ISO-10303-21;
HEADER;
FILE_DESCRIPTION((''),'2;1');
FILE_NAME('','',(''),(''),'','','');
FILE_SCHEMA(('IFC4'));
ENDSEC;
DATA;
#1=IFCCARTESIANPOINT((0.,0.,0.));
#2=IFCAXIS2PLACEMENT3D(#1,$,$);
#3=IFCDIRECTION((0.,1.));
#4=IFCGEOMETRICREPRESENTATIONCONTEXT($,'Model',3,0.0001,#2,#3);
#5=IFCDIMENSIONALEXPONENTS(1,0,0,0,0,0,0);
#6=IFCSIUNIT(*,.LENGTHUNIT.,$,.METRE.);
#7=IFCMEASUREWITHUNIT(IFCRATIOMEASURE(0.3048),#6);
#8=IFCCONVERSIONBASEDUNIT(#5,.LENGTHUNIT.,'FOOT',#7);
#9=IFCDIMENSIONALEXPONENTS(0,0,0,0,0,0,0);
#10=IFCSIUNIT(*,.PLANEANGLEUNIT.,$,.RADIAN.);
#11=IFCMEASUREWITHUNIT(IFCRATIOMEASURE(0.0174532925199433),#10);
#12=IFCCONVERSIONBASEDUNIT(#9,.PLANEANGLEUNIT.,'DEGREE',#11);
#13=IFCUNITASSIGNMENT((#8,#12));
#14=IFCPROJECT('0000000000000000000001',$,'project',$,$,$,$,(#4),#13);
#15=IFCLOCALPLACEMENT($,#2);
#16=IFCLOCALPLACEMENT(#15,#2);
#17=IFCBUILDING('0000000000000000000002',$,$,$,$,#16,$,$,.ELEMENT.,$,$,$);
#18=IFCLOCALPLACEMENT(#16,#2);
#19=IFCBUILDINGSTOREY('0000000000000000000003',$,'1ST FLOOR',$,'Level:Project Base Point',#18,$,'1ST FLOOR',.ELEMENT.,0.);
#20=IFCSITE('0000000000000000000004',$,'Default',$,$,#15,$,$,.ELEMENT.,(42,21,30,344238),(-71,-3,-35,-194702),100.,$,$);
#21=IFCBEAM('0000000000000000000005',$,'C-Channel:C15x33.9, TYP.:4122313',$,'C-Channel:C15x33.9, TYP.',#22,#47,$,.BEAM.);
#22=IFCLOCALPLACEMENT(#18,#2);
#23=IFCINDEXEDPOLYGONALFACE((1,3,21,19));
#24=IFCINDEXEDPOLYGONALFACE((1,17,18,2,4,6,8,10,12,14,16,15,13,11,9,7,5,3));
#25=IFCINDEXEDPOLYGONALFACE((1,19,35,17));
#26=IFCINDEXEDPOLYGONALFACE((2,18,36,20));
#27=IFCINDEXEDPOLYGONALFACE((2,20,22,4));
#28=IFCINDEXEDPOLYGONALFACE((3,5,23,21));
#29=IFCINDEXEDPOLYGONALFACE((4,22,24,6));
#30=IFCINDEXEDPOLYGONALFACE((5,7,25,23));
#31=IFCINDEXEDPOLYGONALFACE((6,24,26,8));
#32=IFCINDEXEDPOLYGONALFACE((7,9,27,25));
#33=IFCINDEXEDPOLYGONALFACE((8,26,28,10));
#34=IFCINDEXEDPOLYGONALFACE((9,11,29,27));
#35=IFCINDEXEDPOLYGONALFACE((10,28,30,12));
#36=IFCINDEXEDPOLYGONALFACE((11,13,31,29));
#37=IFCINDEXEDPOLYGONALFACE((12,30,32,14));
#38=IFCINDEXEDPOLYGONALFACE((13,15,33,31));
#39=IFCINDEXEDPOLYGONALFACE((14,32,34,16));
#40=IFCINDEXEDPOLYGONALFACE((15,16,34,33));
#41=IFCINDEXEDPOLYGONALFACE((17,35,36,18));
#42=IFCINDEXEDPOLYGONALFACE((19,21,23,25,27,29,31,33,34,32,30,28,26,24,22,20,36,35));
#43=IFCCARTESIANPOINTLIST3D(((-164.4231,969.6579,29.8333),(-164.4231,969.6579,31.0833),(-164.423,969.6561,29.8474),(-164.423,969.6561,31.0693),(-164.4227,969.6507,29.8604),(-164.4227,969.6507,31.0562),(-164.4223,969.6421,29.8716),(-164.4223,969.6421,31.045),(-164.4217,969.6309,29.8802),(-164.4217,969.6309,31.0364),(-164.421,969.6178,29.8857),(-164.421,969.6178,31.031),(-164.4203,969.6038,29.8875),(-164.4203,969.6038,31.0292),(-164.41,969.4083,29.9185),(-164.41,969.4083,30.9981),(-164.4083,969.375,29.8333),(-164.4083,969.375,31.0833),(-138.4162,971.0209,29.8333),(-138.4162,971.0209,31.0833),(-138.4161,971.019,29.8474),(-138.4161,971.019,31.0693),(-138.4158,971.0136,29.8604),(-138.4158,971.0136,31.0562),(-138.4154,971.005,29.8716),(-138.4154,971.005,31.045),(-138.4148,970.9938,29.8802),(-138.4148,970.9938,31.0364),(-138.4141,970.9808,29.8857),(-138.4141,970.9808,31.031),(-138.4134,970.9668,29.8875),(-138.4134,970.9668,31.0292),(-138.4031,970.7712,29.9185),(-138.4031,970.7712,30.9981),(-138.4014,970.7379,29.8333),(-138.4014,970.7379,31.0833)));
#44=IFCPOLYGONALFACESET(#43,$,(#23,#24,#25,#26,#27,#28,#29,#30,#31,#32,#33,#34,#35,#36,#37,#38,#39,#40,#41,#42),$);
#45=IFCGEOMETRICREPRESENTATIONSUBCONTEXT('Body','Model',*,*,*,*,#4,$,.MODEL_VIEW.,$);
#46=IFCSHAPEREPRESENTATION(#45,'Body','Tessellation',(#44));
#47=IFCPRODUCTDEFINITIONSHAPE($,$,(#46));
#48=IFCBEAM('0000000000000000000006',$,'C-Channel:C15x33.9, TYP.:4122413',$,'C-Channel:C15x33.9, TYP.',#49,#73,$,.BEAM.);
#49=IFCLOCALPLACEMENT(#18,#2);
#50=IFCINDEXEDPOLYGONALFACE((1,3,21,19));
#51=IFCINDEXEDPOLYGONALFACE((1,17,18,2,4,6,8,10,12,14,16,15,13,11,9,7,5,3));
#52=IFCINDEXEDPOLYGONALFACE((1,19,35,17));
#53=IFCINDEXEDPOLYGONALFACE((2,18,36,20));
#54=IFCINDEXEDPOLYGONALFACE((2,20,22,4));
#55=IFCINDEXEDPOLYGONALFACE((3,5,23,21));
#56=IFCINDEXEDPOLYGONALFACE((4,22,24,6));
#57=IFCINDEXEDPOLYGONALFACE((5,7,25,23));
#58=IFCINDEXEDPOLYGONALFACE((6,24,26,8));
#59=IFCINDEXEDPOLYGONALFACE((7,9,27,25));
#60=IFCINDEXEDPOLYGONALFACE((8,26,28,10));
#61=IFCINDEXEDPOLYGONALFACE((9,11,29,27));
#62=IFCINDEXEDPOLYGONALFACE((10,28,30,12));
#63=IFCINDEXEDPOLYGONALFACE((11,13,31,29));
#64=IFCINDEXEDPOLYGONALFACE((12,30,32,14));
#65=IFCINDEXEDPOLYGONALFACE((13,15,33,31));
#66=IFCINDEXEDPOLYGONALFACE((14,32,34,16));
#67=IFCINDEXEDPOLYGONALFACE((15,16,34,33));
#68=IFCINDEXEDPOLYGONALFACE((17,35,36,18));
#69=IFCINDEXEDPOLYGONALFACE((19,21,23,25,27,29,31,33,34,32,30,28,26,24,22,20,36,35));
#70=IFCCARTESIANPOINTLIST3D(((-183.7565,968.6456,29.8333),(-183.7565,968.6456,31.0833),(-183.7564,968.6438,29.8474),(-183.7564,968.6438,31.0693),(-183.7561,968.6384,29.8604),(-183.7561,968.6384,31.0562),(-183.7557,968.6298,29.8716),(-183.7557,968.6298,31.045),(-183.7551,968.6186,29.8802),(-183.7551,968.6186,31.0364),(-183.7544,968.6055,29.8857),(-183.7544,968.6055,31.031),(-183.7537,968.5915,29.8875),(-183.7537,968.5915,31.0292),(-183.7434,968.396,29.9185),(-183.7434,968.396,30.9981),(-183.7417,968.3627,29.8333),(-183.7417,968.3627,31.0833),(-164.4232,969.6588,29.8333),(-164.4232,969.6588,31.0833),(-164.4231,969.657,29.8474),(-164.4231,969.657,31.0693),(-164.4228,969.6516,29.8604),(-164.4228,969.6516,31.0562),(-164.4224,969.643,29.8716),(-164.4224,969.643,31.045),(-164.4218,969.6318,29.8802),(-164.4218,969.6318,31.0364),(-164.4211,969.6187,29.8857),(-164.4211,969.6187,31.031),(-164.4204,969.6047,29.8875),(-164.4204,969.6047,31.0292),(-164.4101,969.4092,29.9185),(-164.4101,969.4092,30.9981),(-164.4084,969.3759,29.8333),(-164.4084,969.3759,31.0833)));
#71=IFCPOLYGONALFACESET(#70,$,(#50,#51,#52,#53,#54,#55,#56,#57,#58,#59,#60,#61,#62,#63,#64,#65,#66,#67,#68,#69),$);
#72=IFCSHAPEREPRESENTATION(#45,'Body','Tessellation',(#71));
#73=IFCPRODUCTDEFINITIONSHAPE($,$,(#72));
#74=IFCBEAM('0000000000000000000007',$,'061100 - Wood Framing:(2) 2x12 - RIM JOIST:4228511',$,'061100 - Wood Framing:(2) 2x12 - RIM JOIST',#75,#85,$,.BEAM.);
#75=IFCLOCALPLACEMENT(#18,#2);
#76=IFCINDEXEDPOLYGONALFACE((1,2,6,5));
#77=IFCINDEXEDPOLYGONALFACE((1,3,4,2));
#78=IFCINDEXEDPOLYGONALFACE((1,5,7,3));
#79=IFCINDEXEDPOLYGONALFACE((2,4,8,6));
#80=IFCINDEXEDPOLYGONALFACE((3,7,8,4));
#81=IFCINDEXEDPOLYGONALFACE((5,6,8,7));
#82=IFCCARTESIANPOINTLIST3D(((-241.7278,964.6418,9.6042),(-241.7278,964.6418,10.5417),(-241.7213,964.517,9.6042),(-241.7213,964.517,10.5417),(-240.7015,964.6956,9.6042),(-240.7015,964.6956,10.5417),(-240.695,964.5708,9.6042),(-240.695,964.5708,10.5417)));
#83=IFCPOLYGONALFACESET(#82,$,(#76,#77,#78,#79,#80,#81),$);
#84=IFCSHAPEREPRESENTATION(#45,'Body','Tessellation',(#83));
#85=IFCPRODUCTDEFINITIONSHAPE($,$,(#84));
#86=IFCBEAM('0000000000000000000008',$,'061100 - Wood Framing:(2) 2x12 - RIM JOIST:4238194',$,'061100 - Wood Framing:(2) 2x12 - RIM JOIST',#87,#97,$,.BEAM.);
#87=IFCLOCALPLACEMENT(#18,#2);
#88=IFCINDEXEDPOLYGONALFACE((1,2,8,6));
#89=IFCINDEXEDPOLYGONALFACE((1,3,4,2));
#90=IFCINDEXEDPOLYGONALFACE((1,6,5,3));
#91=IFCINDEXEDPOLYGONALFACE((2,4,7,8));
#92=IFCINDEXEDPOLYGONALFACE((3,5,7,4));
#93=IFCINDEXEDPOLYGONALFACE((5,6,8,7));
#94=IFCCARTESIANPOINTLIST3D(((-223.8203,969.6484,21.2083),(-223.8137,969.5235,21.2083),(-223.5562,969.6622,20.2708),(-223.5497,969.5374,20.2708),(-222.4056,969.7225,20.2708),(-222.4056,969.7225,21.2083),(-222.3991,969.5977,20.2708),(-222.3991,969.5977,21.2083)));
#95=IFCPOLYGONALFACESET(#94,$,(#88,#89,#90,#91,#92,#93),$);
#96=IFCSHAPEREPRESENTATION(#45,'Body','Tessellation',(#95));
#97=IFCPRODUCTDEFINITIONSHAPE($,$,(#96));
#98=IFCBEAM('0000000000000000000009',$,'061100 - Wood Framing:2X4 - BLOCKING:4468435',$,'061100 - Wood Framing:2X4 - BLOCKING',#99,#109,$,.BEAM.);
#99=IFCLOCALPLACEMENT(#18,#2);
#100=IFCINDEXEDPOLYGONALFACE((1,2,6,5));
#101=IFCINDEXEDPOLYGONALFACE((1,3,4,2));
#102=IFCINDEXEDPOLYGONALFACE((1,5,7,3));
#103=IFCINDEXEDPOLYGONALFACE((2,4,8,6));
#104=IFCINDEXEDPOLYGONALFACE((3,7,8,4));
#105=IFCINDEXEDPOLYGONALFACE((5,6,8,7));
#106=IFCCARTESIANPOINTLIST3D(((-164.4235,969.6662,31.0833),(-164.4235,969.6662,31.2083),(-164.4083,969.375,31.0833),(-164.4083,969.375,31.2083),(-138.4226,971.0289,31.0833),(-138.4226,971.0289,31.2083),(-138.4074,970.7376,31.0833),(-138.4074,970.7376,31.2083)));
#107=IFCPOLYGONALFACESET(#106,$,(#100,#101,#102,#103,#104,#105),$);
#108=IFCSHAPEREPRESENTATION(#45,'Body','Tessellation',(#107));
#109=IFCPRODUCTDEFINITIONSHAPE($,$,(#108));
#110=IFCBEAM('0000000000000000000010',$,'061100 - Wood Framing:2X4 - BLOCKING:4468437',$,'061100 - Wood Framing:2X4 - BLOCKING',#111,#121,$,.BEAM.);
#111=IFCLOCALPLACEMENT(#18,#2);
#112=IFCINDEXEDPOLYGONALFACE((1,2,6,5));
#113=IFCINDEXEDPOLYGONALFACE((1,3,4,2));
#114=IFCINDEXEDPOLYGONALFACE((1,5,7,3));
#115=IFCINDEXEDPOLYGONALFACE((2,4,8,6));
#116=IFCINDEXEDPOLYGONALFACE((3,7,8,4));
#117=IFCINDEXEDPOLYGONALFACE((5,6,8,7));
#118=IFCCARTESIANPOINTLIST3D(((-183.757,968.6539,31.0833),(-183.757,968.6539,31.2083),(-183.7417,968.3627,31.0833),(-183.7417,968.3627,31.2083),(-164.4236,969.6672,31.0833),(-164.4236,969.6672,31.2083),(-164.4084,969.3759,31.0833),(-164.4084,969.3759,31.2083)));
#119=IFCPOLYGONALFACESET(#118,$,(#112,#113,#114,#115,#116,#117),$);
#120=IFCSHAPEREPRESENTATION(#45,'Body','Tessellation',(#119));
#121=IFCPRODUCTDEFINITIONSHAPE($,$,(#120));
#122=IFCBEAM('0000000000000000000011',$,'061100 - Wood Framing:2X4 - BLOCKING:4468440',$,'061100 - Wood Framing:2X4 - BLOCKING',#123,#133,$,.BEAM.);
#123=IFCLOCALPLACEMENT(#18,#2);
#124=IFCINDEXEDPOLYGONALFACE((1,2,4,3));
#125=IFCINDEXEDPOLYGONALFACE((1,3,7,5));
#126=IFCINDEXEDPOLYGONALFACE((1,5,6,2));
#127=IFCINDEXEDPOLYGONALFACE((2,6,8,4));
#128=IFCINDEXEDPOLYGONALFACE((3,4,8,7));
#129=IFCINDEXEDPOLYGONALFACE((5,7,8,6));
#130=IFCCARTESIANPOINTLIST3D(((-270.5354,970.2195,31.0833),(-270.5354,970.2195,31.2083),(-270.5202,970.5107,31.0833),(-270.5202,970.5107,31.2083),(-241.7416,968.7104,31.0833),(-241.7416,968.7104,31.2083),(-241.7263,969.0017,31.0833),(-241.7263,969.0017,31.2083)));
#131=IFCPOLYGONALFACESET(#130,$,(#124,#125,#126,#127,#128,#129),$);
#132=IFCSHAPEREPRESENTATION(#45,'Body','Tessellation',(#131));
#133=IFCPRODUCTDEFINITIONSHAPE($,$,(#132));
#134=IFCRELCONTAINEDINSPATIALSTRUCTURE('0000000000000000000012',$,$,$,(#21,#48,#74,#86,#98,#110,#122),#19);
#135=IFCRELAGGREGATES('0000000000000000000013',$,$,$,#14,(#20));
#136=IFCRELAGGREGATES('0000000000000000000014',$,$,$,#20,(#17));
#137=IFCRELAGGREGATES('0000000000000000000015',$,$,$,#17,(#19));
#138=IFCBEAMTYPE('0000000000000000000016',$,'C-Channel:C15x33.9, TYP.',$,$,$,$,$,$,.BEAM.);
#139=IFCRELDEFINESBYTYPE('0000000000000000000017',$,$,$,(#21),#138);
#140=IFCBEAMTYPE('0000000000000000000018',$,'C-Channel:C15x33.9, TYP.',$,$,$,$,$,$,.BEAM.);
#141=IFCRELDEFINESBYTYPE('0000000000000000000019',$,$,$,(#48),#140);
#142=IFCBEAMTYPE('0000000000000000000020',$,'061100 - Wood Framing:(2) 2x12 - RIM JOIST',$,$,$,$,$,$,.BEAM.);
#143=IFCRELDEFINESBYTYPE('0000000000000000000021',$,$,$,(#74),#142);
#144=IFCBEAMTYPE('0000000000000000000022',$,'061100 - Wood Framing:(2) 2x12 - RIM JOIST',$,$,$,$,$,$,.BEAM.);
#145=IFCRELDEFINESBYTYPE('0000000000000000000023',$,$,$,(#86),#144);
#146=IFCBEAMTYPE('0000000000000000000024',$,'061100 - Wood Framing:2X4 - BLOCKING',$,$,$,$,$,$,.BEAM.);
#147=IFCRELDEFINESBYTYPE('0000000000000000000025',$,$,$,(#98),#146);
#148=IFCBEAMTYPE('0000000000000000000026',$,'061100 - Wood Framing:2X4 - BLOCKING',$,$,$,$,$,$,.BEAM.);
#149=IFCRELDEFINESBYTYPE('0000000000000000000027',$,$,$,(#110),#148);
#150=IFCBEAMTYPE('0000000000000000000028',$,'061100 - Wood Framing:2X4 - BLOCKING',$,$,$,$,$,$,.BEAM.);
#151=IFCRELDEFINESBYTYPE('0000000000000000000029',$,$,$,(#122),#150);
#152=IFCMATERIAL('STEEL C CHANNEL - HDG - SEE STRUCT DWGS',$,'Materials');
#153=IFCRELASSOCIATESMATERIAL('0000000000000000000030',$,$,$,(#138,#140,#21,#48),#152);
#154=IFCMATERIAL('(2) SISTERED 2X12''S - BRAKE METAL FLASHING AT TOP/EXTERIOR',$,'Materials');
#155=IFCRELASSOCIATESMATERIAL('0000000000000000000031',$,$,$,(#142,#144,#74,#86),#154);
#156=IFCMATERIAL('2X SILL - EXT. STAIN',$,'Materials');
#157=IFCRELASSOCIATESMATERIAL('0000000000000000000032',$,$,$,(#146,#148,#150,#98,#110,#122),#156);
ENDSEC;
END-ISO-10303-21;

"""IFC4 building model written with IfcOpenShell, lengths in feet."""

from ifc_helpers import new_model, entity, si_unit, converted_unit, direction, frame, frame_2d, origin, origin_2d_with_axis, place, context, subcontext, project, spatial, polyline, circle_curve, parameter, trimmed, segment, composite_curve, rectangle, outline, extrude, clip, halfspace, source, transform, mapped, material, material_profile, profile_set, profile_usage, type_object, type_shapes, element, save


model = new_model("IFC4")

# Units and contexts
model_context = context("Model", 3, precision=0.0001, world=origin(), true_north=direction((0.0, 1.0)))
body_context = subcontext(model_context, "Body", "Model", "MODEL_VIEW")
ifc_project = project(units=[converted_unit("LENGTHUNIT", "FOOT", entity("IfcRatioMeasure", 0.3048), si_unit("LENGTHUNIT", "METRE"), dimensions=[1, 0, 0, 0, 0, 0, 0]), converted_unit("PLANEANGLEUNIT", "DEGREE", entity("IfcRatioMeasure", 0.0174532925199433), si_unit("PLANEANGLEUNIT", "RADIAN"), dimensions=[0, 0, 0, 0, 0, 0, 0])], contexts=[model_context])

# Site, building, storey
site_placement = place(None, origin())
site = spatial("IfcSite", under=ifc_project, at=site_placement, Name="Default", CompositionType="ELEMENT", RefLatitude=(42, 21, 30, 344238), RefLongitude=(-71, -3, -35, -194702), RefElevation=100.0)
building_placement = place(site_placement, origin())
building = spatial("IfcBuilding", under=site, at=building_placement, CompositionType="ELEMENT")
storey_placement = place(building_placement, origin())
storey = spatial("IfcBuildingStorey", under=building, at=storey_placement, Name="1ST FLOOR", ObjectType="Level:Project Base Point", LongName="1ST FLOOR", CompositionType="ELEMENT", Elevation=0.0)

# Beams
ifc_material_1 = material(Name="STEEL C CHANNEL - HDG - SEE STRUCT DWGS", Category="Materials")
ifc_material_profile_1 = material_profile(ifc_material_1, outline(composite_curve([segment(polyline([(0.0323, -0.5398, 0.0), (0.0323, 0.5398, 0.0)]), True, "CONTINUOUS"), segment(polyline([(0.0323, 0.5398, 0.0), (-0.1635, 0.5708, 0.0)]), True, "CONTINUOUS"), segment(trimmed(circle_curve(frame((-0.1635, 0.625, 0.0), z_axis=(0.0, 0.0, -1.0), x_axis=(-1.0, 0.0, 0.0)), 0.0542), [parameter(270.0)], [parameter(360.0)], True, "PARAMETER"), True, "CONTINUOUS"), segment(polyline([(-0.2177, 0.625, 0.0), (0.0657, 0.625, 0.0)]), True, "CONTINUOUS"), segment(polyline([(0.0657, 0.625, 0.0), (0.0657, -0.625, 0.0)]), True, "CONTINUOUS"), segment(polyline([(0.0657, -0.625, 0.0), (-0.2177, -0.625, 0.0)]), True, "CONTINUOUS"), segment(trimmed(circle_curve(frame((-0.1635, -0.625, 0.0), z_axis=(0.0, 0.0, -1.0), x_axis=(-1.0, 0.0, 0.0)), 0.0542), [parameter(0.0)], [parameter(90.0)], True, "PARAMETER"), True, "CONTINUOUS"), segment(polyline([(-0.1635, -0.5708, 0.0), (0.0323, -0.5398, 0.0)]), True, "CONTINUOUS")], self_intersect=False), kind="CURVE"), Name="C15x33.9, TYP.")
ifc_profile_set_1 = profile_set([ifc_material_profile_1], Name="C15x33.9, TYP.")
ifc_profile_usage_1 = profile_usage(ifc_profile_set_1, cardinal=8)
beam_type_1 = type_object("IfcBeamType", Name="C-Channel:C15x33.9, TYP.", PredefinedType="BEAM", material=ifc_profile_set_1)
shared_shape_1 = source(origin(), body_context, "Body", "SweptSolid", [
    extrude(outline(composite_curve([segment(polyline([(-0.1469, -0.625), (0.1365, -0.625)]), True, "CONTINUOUS"), segment(polyline([(0.1365, -0.625), (0.1365, 0.625)]), True, "CONTINUOUS"), segment(polyline([(0.1365, 0.625), (-0.1469, 0.625)]), True, "CONTINUOUS"), segment(trimmed(circle_curve(frame_2d((-0.0927, 0.625), x_axis=(-1.0, 0.0)), 0.0542), [parameter(0.0)], [parameter(90.0)], True, "PARAMETER"), True, "CONTINUOUS"), segment(polyline([(-0.0927, 0.5708), (0.1031, 0.5398)]), True, "CONTINUOUS"), segment(polyline([(0.1031, 0.5398), (0.1031, -0.5398)]), True, "CONTINUOUS"), segment(polyline([(0.1031, -0.5398), (-0.0927, -0.5708)]), True, "CONTINUOUS"), segment(trimmed(circle_curve(frame_2d((-0.0927, -0.625), x_axis=(0.0, 1.0)), 0.0542), [parameter(0.0)], [parameter(90.0)], True, "PARAMETER"), True, "CONTINUOUS")], self_intersect=False)), frame((-164.4154, 969.5112, 30.4583), z_axis=(0.99863, 0.052336, 0.0), x_axis=(0.052336, -0.99863, 0.0)), (0.0, 0.0, 1.0), 26.0426),
])
type_shapes(beam_type_1, [shared_shape_1])
beam_1_placement = place(storey_placement, origin())
element("IfcBeam", 1, at=beam_1_placement, inside=storey, type_object=beam_type_1, material=ifc_profile_usage_1, Name="C-Channel:C15x33.9, TYP.:4122313", ObjectType="C-Channel:C15x33.9, TYP.", PredefinedType="BEAM", context=body_context, shape_type="MappedRepresentation", body=[
    mapped(shared_shape_1, transform((0.0, 0.0, 0.0), scale=1.0)),
])
ifc_profile_usage_2 = profile_usage(ifc_profile_set_1, cardinal=8)
beam_type_2 = type_object("IfcBeamType", Name="C-Channel:C15x33.9, TYP.", PredefinedType="BEAM", material=ifc_profile_set_1)
shared_shape_2 = source(origin(), body_context, "Body", "SweptSolid", [
    extrude(outline(composite_curve([segment(polyline([(-0.1469, -0.625), (0.1365, -0.625)]), True, "CONTINUOUS"), segment(polyline([(0.1365, -0.625), (0.1365, 0.625)]), True, "CONTINUOUS"), segment(polyline([(0.1365, 0.625), (-0.1469, 0.625)]), True, "CONTINUOUS"), segment(trimmed(circle_curve(frame_2d((-0.0927, 0.625), x_axis=(-1.0, 0.0)), 0.0542), [parameter(0.0)], [parameter(90.0)], True, "PARAMETER"), True, "CONTINUOUS"), segment(polyline([(-0.0927, 0.5708), (0.1031, 0.5398)]), True, "CONTINUOUS"), segment(polyline([(0.1031, 0.5398), (0.1031, -0.5398)]), True, "CONTINUOUS"), segment(polyline([(0.1031, -0.5398), (-0.0927, -0.5708)]), True, "CONTINUOUS"), segment(trimmed(circle_curve(frame_2d((-0.0927, -0.625), x_axis=(0.0, 1.0)), 0.0542), [parameter(0.0)], [parameter(90.0)], True, "PARAMETER"), True, "CONTINUOUS")], self_intersect=False)), frame((-164.4155, 969.5122, 30.4583), z_axis=(-0.99863, -0.052336, 0.0), x_axis=(0.052336, -0.99863, 0.0)), (0.0, 0.0, 1.0), 19.3599),
])
type_shapes(beam_type_2, [shared_shape_2])
beam_2_placement = place(storey_placement, origin())
element("IfcBeam", 2, at=beam_2_placement, inside=storey, type_object=beam_type_2, material=ifc_profile_usage_2, Name="C-Channel:C15x33.9, TYP.:4122413", ObjectType="C-Channel:C15x33.9, TYP.", PredefinedType="BEAM", context=body_context, shape_type="MappedRepresentation", body=[
    mapped(shared_shape_2, transform((0.0, 0.0, 0.0), scale=1.0)),
])
ifc_material_2 = material(Name="(2) SISTERED 2X12'S - BRAKE METAL FLASHING AT TOP/EXTERIOR", Category="Materials")
ifc_material_profile_2 = material_profile(ifc_material_2, rectangle(XDim=0.9375, YDim=0.125, at=frame_2d((0.0, 0.0), x_axis=(1.0, 0.0))), Name="(2) 2x12 - RIM JOIST")
ifc_profile_set_2 = profile_set([ifc_material_profile_2], Name="(2) 2x12 - RIM JOIST")
ifc_profile_usage_3 = profile_usage(ifc_profile_set_2, cardinal=2)
beam_type_3 = type_object("IfcBeamType", Name="061100 - Wood Framing:(2) 2x12 - RIM JOIST", PredefinedType="BEAM", material=ifc_profile_set_2)
shared_shape_3 = source(origin(), body_context, "Body", "SweptSolid", [
    extrude(rectangle(XDim=0.9375, YDim=0.125, at=frame_2d((0.0, 0.0), x_axis=(1.0, 0.0))), frame((-241.7246, 964.5794, 10.0729), z_axis=(0.99863, 0.052336, 0.0), x_axis=(0.0, 0.0, 1.0)), (0.0, 0.0, 1.0), 1.0278),
])
type_shapes(beam_type_3, [shared_shape_3])
beam_3_placement = place(storey_placement, origin())
element("IfcBeam", 3, at=beam_3_placement, inside=storey, type_object=beam_type_3, material=ifc_profile_usage_3, Name="061100 - Wood Framing:(2) 2x12 - RIM JOIST:4228511", ObjectType="061100 - Wood Framing:(2) 2x12 - RIM JOIST", PredefinedType="BEAM", context=body_context, shape_type="MappedRepresentation", body=[
    mapped(shared_shape_3, transform((0.0, 0.0, 0.0), scale=1.0)),
])
ifc_profile_usage_4 = profile_usage(ifc_profile_set_2, cardinal=2)
beam_type_4 = type_object("IfcBeamType", Name="061100 - Wood Framing:(2) 2x12 - RIM JOIST", PredefinedType="BEAM", material=ifc_profile_set_2)
shared_shape_4 = source(origin(), body_context, "Body", "Clipping", [
    clip(extrude(rectangle(XDim=0.9375, YDim=0.125, at=frame_2d((0.0, 0.0), x_axis=(1.0, 0.0))), frame((-223.817, 969.586, 20.7396), z_axis=(0.99863, 0.052336, 0.0), x_axis=(0.0, 0.0, 1.0)), (0.0, 0.0, 1.0), 1.4166), halfspace(frame((-223.2632, 966.4176, 19.8354), z_axis=(-0.961136, -0.050371, -0.27144), x_axis=(0.271068, 0.014206, -0.962455)), False)),
])
type_shapes(beam_type_4, [shared_shape_4])
beam_4_placement = place(storey_placement, origin())
element("IfcBeam", 4, at=beam_4_placement, inside=storey, type_object=beam_type_4, material=ifc_profile_usage_4, Name="061100 - Wood Framing:(2) 2x12 - RIM JOIST:4238194", ObjectType="061100 - Wood Framing:(2) 2x12 - RIM JOIST", PredefinedType="BEAM", context=body_context, shape_type="MappedRepresentation", body=[
    mapped(shared_shape_4, transform((0.0, 0.0, 0.0), scale=1.0)),
])
ifc_material_3 = material(Name="2X SILL - EXT. STAIN", Category="Materials")
ifc_material_profile_3 = material_profile(ifc_material_3, rectangle(XDim=0.125, YDim=0.2917, at=origin_2d_with_axis()), Name="2X4 - BLOCKING")
ifc_profile_set_3 = profile_set([ifc_material_profile_3], Name="2X4 - BLOCKING")
ifc_profile_usage_5 = profile_usage(ifc_profile_set_3, cardinal=8)
beam_type_5 = type_object("IfcBeamType", Name="061100 - Wood Framing:2X4 - BLOCKING", PredefinedType="BEAM", material=ifc_profile_set_3)
shared_shape_5 = source(origin(), body_context, "Body", "SweptSolid", [
    extrude(rectangle(XDim=0.125, YDim=0.2917, at=origin_2d_with_axis()), frame((-164.4159, 969.5206, 31.1458), z_axis=(0.99863, 0.052336, 0.0), x_axis=(0.0, 0.0, 1.0)), (0.0, 0.0, 1.0), 26.0366),
])
type_shapes(beam_type_5, [shared_shape_5])
beam_5_placement = place(storey_placement, origin())
element("IfcBeam", 5, at=beam_5_placement, inside=storey, type_object=beam_type_5, material=ifc_profile_usage_5, Name="061100 - Wood Framing:2X4 - BLOCKING:4468435", ObjectType="061100 - Wood Framing:2X4 - BLOCKING", PredefinedType="BEAM", context=body_context, shape_type="MappedRepresentation", body=[
    mapped(shared_shape_5, transform((0.0, 0.0, 0.0), scale=1.0)),
])
ifc_profile_usage_6 = profile_usage(ifc_profile_set_3, cardinal=8)
beam_type_6 = type_object("IfcBeamType", Name="061100 - Wood Framing:2X4 - BLOCKING", PredefinedType="BEAM", material=ifc_profile_set_3)
shared_shape_6 = source(origin(), body_context, "Body", "SweptSolid", [
    extrude(rectangle(XDim=0.125, YDim=0.2917, at=frame_2d((0.0, 0.0), x_axis=(1.0, 0.0))), frame((-164.416, 969.5215, 31.1458), z_axis=(-0.99863, -0.052336, 0.0), x_axis=(0.0, 0.0, -1.0)), (0.0, 0.0, 1.0), 19.3599),
])
type_shapes(beam_type_6, [shared_shape_6])
beam_6_placement = place(storey_placement, origin())
element("IfcBeam", 6, at=beam_6_placement, inside=storey, type_object=beam_type_6, material=ifc_profile_usage_6, Name="061100 - Wood Framing:2X4 - BLOCKING:4468437", ObjectType="061100 - Wood Framing:2X4 - BLOCKING", PredefinedType="BEAM", context=body_context, shape_type="MappedRepresentation", body=[
    mapped(shared_shape_6, transform((0.0, 0.0, 0.0), scale=1.0)),
])
ifc_profile_usage_7 = profile_usage(ifc_profile_set_3, cardinal=8)
beam_type_7 = type_object("IfcBeamType", Name="061100 - Wood Framing:2X4 - BLOCKING", PredefinedType="BEAM", material=ifc_profile_set_3)
shared_shape_7 = source(origin(), body_context, "Body", "SweptSolid", [
    extrude(rectangle(XDim=0.125, YDim=0.2917, at=frame_2d((0.0, 0.0), x_axis=(1.0, 0.0))), frame((-241.734, 968.8561, 31.1458), z_axis=(-0.99863, 0.052336, 0.0), x_axis=(0.0, 0.0, 1.0)), (0.0, 0.0, 1.0), 28.8333),
])
type_shapes(beam_type_7, [shared_shape_7])
beam_7_placement = place(storey_placement, origin())
element("IfcBeam", 7, at=beam_7_placement, inside=storey, type_object=beam_type_7, material=ifc_profile_usage_7, Name="061100 - Wood Framing:2X4 - BLOCKING:4468440", ObjectType="061100 - Wood Framing:2X4 - BLOCKING", PredefinedType="BEAM", context=body_context, shape_type="MappedRepresentation", body=[
    mapped(shared_shape_7, transform((0.0, 0.0, 0.0), scale=1.0)),
])

save(model, "model.ifc")
